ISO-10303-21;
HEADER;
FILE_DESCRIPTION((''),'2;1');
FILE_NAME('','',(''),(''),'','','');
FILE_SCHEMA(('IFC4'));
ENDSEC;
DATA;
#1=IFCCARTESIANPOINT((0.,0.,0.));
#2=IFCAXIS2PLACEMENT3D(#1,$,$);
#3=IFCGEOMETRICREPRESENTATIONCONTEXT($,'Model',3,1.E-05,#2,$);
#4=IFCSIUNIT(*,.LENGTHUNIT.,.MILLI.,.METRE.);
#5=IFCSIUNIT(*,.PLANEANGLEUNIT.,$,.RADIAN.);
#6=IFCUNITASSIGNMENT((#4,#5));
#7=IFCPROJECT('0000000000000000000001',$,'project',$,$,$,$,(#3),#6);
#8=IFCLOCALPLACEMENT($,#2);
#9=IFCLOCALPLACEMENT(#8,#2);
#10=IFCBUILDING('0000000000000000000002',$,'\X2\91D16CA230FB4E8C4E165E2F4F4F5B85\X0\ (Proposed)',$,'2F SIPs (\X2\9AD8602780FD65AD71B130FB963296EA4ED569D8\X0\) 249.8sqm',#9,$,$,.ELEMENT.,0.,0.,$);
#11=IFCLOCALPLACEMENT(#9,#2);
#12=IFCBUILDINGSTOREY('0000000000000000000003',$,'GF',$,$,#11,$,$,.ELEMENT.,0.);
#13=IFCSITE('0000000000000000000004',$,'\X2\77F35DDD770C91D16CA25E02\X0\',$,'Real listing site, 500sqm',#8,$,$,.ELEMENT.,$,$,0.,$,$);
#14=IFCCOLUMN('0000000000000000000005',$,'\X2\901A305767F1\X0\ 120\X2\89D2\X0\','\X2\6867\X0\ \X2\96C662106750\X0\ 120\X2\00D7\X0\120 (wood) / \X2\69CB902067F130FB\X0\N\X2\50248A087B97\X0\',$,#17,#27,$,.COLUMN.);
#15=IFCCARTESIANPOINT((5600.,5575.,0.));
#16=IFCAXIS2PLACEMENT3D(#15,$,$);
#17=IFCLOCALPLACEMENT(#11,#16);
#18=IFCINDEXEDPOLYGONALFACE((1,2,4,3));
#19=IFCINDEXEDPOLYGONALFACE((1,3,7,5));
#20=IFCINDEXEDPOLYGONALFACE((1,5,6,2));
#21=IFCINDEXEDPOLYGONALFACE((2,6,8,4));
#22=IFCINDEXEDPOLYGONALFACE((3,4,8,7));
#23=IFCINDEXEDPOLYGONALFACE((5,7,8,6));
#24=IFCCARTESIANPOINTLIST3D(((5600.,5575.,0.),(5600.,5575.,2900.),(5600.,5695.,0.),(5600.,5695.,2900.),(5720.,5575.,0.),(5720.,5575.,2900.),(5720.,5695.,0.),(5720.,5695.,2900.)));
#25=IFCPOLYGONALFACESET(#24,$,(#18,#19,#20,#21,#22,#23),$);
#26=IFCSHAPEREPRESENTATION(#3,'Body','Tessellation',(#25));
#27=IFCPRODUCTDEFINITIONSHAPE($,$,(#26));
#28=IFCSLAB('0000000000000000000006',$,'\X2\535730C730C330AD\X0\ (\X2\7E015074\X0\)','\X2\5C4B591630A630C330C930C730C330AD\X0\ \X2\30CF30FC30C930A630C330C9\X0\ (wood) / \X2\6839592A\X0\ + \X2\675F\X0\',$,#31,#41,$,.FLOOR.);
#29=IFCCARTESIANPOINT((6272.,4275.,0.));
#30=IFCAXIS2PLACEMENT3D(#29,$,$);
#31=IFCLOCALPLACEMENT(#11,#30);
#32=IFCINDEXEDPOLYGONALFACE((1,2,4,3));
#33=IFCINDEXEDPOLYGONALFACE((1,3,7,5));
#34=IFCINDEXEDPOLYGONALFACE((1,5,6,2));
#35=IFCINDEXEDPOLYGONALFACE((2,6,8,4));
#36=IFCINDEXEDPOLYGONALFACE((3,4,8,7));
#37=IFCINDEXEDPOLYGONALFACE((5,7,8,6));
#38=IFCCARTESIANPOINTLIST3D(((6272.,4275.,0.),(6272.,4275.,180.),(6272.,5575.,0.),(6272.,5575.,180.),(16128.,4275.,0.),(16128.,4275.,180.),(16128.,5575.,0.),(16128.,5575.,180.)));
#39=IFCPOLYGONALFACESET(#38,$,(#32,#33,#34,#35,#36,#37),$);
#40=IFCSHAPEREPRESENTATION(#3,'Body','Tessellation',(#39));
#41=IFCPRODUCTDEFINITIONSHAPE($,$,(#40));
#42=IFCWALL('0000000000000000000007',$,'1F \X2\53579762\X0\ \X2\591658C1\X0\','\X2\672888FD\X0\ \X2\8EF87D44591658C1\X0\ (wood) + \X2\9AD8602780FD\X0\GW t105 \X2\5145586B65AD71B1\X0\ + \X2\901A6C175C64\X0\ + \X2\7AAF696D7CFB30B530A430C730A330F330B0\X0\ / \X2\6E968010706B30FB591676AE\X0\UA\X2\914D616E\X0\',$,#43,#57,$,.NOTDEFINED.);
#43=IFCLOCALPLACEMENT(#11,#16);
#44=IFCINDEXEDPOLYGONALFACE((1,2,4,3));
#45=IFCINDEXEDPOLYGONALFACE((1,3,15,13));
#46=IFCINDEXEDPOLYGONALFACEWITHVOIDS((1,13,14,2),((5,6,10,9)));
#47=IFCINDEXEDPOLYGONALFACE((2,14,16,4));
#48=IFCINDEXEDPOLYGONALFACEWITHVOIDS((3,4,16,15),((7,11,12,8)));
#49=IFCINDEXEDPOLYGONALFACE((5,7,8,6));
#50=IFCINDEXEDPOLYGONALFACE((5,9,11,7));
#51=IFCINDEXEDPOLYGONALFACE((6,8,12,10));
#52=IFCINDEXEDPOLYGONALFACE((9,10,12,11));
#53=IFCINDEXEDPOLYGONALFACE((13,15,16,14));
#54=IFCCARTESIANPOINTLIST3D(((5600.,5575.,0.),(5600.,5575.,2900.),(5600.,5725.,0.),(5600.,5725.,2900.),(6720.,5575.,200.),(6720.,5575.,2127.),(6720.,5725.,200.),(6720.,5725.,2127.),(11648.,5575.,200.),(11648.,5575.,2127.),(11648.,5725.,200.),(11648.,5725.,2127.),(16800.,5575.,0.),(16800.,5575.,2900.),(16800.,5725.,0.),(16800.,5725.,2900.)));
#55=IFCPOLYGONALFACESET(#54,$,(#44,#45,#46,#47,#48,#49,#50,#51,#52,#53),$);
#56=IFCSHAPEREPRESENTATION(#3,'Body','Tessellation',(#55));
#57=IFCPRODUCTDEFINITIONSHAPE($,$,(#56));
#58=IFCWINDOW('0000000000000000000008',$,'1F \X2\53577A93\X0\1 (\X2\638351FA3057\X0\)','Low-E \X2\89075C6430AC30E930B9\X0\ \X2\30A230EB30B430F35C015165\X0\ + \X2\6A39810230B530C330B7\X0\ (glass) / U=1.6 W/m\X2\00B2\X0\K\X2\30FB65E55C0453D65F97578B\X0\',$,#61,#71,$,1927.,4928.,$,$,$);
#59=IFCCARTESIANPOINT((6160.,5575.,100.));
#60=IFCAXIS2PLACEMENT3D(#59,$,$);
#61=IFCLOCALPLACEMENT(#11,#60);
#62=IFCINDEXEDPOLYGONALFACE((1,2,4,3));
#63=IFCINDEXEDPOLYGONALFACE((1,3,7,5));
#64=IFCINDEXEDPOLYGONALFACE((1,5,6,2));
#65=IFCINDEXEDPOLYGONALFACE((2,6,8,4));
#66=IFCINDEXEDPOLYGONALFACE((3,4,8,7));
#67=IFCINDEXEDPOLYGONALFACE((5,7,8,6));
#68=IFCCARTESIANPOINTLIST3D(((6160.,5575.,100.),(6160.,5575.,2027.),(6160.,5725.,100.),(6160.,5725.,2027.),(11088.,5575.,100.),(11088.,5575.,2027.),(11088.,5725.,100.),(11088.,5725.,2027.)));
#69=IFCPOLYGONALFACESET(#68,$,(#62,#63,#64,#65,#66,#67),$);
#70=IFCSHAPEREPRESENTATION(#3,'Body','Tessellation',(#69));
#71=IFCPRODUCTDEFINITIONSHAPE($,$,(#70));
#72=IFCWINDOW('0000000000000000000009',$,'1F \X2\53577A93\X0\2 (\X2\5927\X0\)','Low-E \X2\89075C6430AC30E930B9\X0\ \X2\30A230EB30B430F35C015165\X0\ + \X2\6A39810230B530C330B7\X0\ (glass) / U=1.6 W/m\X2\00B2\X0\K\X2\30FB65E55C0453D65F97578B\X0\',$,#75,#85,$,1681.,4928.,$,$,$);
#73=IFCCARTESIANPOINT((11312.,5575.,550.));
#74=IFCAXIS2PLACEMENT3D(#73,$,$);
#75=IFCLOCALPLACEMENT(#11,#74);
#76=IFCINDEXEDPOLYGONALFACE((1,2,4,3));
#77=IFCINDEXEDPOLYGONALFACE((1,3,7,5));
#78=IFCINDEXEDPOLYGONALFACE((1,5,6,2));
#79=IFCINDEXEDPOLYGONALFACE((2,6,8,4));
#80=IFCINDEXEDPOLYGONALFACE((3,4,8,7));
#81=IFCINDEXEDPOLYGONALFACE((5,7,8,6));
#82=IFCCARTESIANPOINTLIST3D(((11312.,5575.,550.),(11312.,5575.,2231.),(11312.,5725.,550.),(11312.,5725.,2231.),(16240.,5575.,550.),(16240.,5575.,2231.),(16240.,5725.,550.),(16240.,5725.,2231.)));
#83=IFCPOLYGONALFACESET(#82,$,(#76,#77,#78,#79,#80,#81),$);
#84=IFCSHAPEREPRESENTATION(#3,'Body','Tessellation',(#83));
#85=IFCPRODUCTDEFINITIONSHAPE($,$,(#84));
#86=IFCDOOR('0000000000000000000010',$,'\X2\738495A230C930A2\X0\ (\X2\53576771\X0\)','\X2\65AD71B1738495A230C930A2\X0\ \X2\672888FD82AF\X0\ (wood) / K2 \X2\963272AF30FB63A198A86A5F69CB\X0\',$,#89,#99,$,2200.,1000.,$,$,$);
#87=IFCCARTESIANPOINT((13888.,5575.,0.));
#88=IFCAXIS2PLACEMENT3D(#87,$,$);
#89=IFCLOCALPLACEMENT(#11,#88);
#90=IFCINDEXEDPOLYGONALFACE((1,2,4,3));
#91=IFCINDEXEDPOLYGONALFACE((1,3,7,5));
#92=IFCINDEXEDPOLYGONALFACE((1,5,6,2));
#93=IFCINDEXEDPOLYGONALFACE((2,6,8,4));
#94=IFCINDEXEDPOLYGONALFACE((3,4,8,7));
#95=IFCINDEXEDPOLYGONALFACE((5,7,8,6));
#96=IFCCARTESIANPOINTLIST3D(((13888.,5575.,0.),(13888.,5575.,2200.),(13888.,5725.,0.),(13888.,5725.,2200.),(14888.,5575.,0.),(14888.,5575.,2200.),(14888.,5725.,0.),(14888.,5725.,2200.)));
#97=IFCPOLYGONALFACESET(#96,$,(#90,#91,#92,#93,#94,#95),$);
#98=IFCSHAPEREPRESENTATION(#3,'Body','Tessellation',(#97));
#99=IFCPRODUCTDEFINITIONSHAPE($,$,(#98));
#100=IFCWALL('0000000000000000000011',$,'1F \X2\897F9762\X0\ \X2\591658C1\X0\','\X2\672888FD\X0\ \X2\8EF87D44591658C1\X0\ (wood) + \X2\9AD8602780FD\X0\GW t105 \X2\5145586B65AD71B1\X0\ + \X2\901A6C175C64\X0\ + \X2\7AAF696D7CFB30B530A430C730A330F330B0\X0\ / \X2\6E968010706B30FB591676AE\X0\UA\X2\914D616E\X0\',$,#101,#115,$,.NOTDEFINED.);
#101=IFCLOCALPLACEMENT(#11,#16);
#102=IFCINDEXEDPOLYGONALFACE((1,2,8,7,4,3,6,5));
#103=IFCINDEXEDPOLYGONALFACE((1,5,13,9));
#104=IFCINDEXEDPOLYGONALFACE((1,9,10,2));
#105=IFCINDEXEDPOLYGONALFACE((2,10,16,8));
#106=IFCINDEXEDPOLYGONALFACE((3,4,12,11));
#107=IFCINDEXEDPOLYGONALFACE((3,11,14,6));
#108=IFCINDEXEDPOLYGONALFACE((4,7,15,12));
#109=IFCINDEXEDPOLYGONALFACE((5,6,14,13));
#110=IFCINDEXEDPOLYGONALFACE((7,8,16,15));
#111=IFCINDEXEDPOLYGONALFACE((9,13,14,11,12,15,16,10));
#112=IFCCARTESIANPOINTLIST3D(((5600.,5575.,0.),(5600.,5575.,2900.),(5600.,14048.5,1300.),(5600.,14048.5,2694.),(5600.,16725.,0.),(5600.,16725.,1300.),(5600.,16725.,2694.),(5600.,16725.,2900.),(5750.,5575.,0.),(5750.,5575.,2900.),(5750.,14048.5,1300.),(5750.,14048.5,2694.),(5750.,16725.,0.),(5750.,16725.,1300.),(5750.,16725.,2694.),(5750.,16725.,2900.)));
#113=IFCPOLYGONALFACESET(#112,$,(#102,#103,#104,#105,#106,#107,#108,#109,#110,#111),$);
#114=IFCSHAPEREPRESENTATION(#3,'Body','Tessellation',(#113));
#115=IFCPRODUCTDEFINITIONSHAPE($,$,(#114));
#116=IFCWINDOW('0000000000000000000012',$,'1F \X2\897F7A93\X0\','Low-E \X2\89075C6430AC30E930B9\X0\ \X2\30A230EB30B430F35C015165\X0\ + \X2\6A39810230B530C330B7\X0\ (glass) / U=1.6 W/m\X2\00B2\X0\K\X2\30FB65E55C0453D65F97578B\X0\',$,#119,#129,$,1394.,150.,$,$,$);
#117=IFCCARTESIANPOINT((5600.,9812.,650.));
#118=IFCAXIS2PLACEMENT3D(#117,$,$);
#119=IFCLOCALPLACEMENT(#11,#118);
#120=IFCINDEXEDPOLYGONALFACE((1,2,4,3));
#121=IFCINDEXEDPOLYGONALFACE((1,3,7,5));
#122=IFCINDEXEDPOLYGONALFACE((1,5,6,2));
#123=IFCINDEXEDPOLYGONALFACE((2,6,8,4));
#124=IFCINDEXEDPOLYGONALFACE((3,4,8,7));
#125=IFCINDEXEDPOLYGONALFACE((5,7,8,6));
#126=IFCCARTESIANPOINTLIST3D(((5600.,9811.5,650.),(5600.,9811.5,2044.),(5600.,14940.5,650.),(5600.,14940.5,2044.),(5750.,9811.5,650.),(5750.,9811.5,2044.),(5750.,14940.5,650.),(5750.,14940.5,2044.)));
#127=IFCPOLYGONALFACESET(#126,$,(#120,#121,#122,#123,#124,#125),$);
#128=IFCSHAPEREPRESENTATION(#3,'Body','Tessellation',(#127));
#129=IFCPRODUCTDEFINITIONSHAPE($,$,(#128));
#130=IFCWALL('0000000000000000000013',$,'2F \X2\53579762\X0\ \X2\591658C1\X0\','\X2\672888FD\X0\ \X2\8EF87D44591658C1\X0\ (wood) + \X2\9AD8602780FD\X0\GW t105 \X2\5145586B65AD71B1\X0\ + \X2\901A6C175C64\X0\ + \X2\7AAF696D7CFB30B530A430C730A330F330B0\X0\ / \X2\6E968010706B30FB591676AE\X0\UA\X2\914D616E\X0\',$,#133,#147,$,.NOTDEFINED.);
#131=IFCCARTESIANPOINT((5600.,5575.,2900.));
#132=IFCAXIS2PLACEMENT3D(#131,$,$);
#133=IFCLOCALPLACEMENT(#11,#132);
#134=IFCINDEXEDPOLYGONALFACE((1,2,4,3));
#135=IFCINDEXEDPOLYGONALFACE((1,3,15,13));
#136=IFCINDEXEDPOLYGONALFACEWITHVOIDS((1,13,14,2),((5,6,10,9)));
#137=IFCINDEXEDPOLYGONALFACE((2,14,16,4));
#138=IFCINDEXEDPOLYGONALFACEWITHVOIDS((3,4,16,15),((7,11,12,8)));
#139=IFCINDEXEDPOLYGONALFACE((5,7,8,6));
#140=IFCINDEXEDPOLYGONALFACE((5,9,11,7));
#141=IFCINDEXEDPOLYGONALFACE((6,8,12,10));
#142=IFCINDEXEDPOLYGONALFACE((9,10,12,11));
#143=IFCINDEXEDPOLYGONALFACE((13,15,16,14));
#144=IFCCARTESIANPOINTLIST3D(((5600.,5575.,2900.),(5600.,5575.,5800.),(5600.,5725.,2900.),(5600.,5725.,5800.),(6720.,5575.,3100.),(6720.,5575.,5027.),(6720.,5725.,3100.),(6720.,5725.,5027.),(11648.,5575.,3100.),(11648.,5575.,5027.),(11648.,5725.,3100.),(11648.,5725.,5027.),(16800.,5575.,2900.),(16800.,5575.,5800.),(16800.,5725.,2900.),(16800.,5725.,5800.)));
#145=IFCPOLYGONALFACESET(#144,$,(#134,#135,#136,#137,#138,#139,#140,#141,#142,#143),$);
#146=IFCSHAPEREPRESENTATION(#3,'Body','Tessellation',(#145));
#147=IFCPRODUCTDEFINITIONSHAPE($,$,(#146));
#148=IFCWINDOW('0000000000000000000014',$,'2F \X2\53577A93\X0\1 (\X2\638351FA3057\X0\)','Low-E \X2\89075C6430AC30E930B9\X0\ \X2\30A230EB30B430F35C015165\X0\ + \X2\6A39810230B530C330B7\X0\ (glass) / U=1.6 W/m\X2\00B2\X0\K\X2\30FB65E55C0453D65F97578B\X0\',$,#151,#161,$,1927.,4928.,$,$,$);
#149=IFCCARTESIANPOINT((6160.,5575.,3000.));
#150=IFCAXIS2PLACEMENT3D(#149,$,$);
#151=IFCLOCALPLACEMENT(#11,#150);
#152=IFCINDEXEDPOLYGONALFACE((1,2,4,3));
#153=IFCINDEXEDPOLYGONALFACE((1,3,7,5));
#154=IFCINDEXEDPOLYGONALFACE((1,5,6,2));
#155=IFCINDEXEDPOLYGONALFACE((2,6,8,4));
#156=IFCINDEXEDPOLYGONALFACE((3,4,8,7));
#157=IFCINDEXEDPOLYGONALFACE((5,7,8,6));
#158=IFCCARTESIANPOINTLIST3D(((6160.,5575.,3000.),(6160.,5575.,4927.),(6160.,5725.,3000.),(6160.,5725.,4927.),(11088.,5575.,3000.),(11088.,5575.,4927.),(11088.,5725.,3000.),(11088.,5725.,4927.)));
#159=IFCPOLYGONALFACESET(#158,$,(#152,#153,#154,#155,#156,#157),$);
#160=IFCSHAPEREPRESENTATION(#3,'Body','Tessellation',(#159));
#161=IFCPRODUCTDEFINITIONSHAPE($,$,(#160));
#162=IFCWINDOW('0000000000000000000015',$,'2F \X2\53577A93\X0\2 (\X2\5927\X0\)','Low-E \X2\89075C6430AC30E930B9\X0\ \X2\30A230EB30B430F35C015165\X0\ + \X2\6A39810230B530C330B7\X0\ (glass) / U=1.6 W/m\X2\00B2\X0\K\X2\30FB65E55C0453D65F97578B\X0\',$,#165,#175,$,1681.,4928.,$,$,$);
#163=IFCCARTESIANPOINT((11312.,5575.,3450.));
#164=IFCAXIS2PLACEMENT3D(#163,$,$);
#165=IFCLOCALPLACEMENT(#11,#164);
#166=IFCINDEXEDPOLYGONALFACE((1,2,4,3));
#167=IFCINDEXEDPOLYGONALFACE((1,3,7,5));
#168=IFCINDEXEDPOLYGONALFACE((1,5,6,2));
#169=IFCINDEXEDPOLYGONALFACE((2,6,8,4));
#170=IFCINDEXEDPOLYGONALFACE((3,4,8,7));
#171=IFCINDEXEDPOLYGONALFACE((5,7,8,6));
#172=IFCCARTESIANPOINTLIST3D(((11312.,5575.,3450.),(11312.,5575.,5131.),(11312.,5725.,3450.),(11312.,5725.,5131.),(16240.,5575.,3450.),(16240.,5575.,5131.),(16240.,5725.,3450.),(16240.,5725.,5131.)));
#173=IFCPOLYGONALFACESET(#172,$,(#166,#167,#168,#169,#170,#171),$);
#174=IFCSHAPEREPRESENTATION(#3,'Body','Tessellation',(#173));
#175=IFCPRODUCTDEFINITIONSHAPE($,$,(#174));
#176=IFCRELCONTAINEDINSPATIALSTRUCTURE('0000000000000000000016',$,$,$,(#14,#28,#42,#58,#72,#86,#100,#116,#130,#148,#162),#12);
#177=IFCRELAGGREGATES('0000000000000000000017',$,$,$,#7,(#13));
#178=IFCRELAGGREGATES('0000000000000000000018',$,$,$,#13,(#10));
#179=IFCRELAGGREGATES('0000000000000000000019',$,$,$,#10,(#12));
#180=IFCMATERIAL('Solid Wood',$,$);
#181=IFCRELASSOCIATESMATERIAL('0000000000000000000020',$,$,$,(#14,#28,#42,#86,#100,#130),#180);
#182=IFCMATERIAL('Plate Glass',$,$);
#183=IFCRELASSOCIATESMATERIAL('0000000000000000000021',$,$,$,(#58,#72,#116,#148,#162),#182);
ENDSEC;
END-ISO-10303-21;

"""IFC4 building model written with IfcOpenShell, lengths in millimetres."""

from ifc_helpers import new_model, si_unit, frame, frame_2d, origin, place, context, project, spatial, rectangle, extrude, material, element, fill, save


model = new_model("IFC4")

# Units and contexts
model_context = context("Model", 3, precision=1e-05, world=origin())
ifc_project = project(units=[si_unit("LENGTHUNIT", "METRE", prefix="MILLI"), si_unit("PLANEANGLEUNIT", "RADIAN")], contexts=[model_context])

# Site, building, storey
site_placement = place(None, origin())
site = spatial("IfcSite", under=ifc_project, at=site_placement, Name="石川県金沢市", ObjectType="Real listing site, 500sqm", CompositionType="ELEMENT", RefElevation=0.0)
building_placement = place(site_placement, origin())
building = spatial("IfcBuilding", under=site, at=building_placement, Name="金沢・二世帯住宅 (Proposed)", ObjectType="2F SIPs (高性能断熱・防雪仕様) 249.8sqm", CompositionType="ELEMENT", ElevationOfRefHeight=0.0, ElevationOfTerrain=0.0)
storey_placement = place(building_placement, origin())
storey = spatial("IfcBuildingStorey", under=building, at=storey_placement, Name="GF", CompositionType="ELEMENT", Elevation=0.0)

# Column
ifc_material_1 = material(Name="Solid Wood")
column_placement = place(storey_placement, frame((5600.0, 5575.0, 0.0)))
element("IfcColumn", 1, at=column_placement, inside=storey, material=ifc_material_1, Name="通し柱 120角", Description="桧 集成材 120×120 (wood) / 構造柱・N値計算", PredefinedType="COLUMN", context=model_context, shape_type="SweptSolid", body=[
    extrude(rectangle(XDim=120.0, YDim=120.0, at=frame_2d((60.0, 60.0))), frame((5600.0, 5575.0, 0.0)), (0.0, 0.0, 1.0), 2900.0),
])

# Slab
slab_1_placement = place(storey_placement, frame((6272.0, 4275.0, 0.0)))
element("IfcSlab", 2, at=slab_1_placement, inside=storey, material=ifc_material_1, Name="南デッキ (縁側)", Description="屋外ウッドデッキ ハードウッド (wood) / 根太 + 束", PredefinedType="FLOOR", context=model_context, shape_type="SweptSolid", body=[
    extrude(rectangle(XDim=9856.0, YDim=1300.0, at=frame_2d((4928.0, 650.0))), frame((6272.0, 4275.0, 0.0)), (0.0, 0.0, 1.0), 180.0),
])

# Wall, openings, windows, door
wall_1_placement = place(storey_placement, frame((5600.0, 5575.0, 0.0)))
wall_1 = element("IfcWall", 3, at=wall_1_placement, inside=storey, material=ifc_material_1, Name="1F 南面 外壁", Description="木製 軸組外壁 (wood) + 高性能GW t105 充填断熱 + 通気層 + 窯業系サイディング / 準耐火・外皮UA配慮", PredefinedType="NOTDEFINED", context=model_context, shape_type="SweptSolid", body=[
    extrude(rectangle(XDim=11200.0, YDim=150.0, at=frame_2d((5600.0, 75.0))), frame((5600.0, 5575.0, 0.0)), (0.0, 0.0, 1.0), 2900.0),
])
opening_1_placement = place(storey_placement, frame((6160.0, 5575.0, 100.0)))
opening_1 = element("IfcOpeningElement", 4, at=opening_1_placement, cuts=wall_1, PredefinedType="NOTDEFINED", context=model_context, shape_type="SweptSolid", body=[
    extrude(rectangle(XDim=4928.0, YDim=150.0, at=frame_2d((2464.0, 75.0))), frame((6160.0, 5575.0, 100.0)), (0.0, 0.0, 1.0), 1927.0),
])
opening_2_placement = place(storey_placement, frame((11312.0, 5575.0, 550.0)))
opening_2 = element("IfcOpeningElement", 5, at=opening_2_placement, cuts=wall_1, PredefinedType="NOTDEFINED", context=model_context, shape_type="SweptSolid", body=[
    extrude(rectangle(XDim=4928.0, YDim=150.0, at=frame_2d((2464.0, 75.0))), frame((11312.0, 5575.0, 550.0)), (0.0, 0.0, 1.0), 1681.0),
])
opening_3_placement = place(storey_placement, frame((13888.0, 5575.0, 0.0)))
opening_3 = element("IfcOpeningElement", 6, at=opening_3_placement, cuts=wall_1, PredefinedType="NOTDEFINED", context=model_context, shape_type="SweptSolid", body=[
    extrude(rectangle(XDim=1000.0, YDim=150.0, at=frame_2d((500.0, 75.0))), frame((13888.0, 5575.0, 0.0)), (0.0, 0.0, 1.0), 2200.0),
])
ifc_material_2 = material(Name="Plate Glass")
window_1_placement = place(storey_placement, frame((6160.0, 5575.0, 100.0)))
window_1 = element("IfcWindow", 7, at=window_1_placement, inside=storey, material=ifc_material_2, Name="1F 南窓1 (掃出し)", Description="Low-E 複層ガラス アルゴン封入 + 樹脂サッシ (glass) / U=1.6 W/m²K・日射取得型", OverallHeight=1927.0, OverallWidth=4928.0, context=model_context, shape_type="SweptSolid", body=[
    extrude(rectangle(XDim=4928.0, YDim=150.0, at=frame_2d((2464.0, 75.0))), frame((6160.0, 5575.0, 100.0)), (0.0, 0.0, 1.0), 1927.0),
])
fill(opening_1, window_1)
window_2_placement = place(storey_placement, frame((11312.0, 5575.0, 550.0)))
window_2 = element("IfcWindow", 8, at=window_2_placement, inside=storey, material=ifc_material_2, Name="1F 南窓2 (大)", Description="Low-E 複層ガラス アルゴン封入 + 樹脂サッシ (glass) / U=1.6 W/m²K・日射取得型", OverallHeight=1681.0, OverallWidth=4928.0, context=model_context, shape_type="SweptSolid", body=[
    extrude(rectangle(XDim=4928.0, YDim=150.0, at=frame_2d((2464.0, 75.0))), frame((11312.0, 5575.0, 550.0)), (0.0, 0.0, 1.0), 1681.0),
])
fill(opening_2, window_2)
door_placement = place(storey_placement, frame((13888.0, 5575.0, 0.0)))
door = element("IfcDoor", 9, at=door_placement, inside=storey, material=ifc_material_1, Name="玄関ドア (南東)", Description="断熱玄関ドア 木製芯 (wood) / K2 防犯・採風機構", OverallHeight=2200.0, OverallWidth=1000.0, context=model_context, shape_type="SweptSolid", body=[
    extrude(rectangle(XDim=1000.0, YDim=150.0, at=frame_2d((500.0, 75.0))), frame((13888.0, 5575.0, 0.0)), (0.0, 0.0, 1.0), 2200.0),
])
fill(opening_3, door)

# Wall, opening, window
wall_2_placement = place(storey_placement, frame((5600.0, 5575.0, 0.0)))
wall_2 = element("IfcWall", 10, at=wall_2_placement, inside=storey, material=ifc_material_1, Name="1F 西面 外壁", Description="木製 軸組外壁 (wood) + 高性能GW t105 充填断熱 + 通気層 + 窯業系サイディング / 準耐火・外皮UA配慮", PredefinedType="NOTDEFINED", context=model_context, shape_type="SweptSolid", body=[
    extrude(rectangle(XDim=150.0, YDim=11150.0, at=frame_2d((75.0, 5575.0))), frame((5600.0, 5575.0, 0.0)), (0.0, 0.0, 1.0), 2900.0),
])
opening_4_placement = place(storey_placement, frame((5600.0, 9812.0, 650.0)))
opening_4 = element("IfcOpeningElement", 11, at=opening_4_placement, cuts=wall_2, PredefinedType="NOTDEFINED", context=model_context, shape_type="SweptSolid", body=[
    extrude(rectangle(XDim=150.0, YDim=5129.0, at=frame_2d((75.0, 2564.0))), frame((5600.0, 9812.0, 650.0)), (0.0, 0.0, 1.0), 1394.0),
])
window_3_placement = place(storey_placement, frame((5600.0, 9812.0, 650.0)))
window_3 = element("IfcWindow", 12, at=window_3_placement, inside=storey, material=ifc_material_2, Name="1F 西窓", Description="Low-E 複層ガラス アルゴン封入 + 樹脂サッシ (glass) / U=1.6 W/m²K・日射取得型", OverallHeight=1394.0, OverallWidth=150.0, context=model_context, shape_type="SweptSolid", body=[
    extrude(rectangle(XDim=150.0, YDim=5129.0, at=frame_2d((75.0, 2564.0))), frame((5600.0, 9812.0, 650.0)), (0.0, 0.0, 1.0), 1394.0),
])
fill(opening_4, window_3)

# Wall, openings, windows
wall_3_placement = place(storey_placement, frame((5600.0, 5575.0, 2900.0)))
wall_3 = element("IfcWall", 13, at=wall_3_placement, inside=storey, material=ifc_material_1, Name="2F 南面 外壁", Description="木製 軸組外壁 (wood) + 高性能GW t105 充填断熱 + 通気層 + 窯業系サイディング / 準耐火・外皮UA配慮", PredefinedType="NOTDEFINED", context=model_context, shape_type="SweptSolid", body=[
    extrude(rectangle(XDim=11200.0, YDim=150.0, at=frame_2d((5600.0, 75.0))), frame((5600.0, 5575.0, 2900.0)), (0.0, 0.0, 1.0), 2900.0),
])
opening_5_placement = place(storey_placement, frame((6160.0, 5575.0, 3000.0)))
opening_5 = element("IfcOpeningElement", 14, at=opening_5_placement, cuts=wall_3, PredefinedType="NOTDEFINED", context=model_context, shape_type="SweptSolid", body=[
    extrude(rectangle(XDim=4928.0, YDim=150.0, at=frame_2d((2464.0, 75.0))), frame((6160.0, 5575.0, 3000.0)), (0.0, 0.0, 1.0), 1927.0),
])
opening_6_placement = place(storey_placement, frame((11312.0, 5575.0, 3450.0)))
opening_6 = element("IfcOpeningElement", 15, at=opening_6_placement, cuts=wall_3, PredefinedType="NOTDEFINED", context=model_context, shape_type="SweptSolid", body=[
    extrude(rectangle(XDim=4928.0, YDim=150.0, at=frame_2d((2464.0, 75.0))), frame((11312.0, 5575.0, 3450.0)), (0.0, 0.0, 1.0), 1681.0),
])
window_4_placement = place(storey_placement, frame((6160.0, 5575.0, 3000.0)))
window_4 = element("IfcWindow", 16, at=window_4_placement, inside=storey, material=ifc_material_2, Name="2F 南窓1 (掃出し)", Description="Low-E 複層ガラス アルゴン封入 + 樹脂サッシ (glass) / U=1.6 W/m²K・日射取得型", OverallHeight=1927.0, OverallWidth=4928.0, context=model_context, shape_type="SweptSolid", body=[
    extrude(rectangle(XDim=4928.0, YDim=150.0, at=frame_2d((2464.0, 75.0))), frame((6160.0, 5575.0, 3000.0)), (0.0, 0.0, 1.0), 1927.0),
])
fill(opening_5, window_4)
window_5_placement = place(storey_placement, frame((11312.0, 5575.0, 3450.0)))
window_5 = element("IfcWindow", 17, at=window_5_placement, inside=storey, material=ifc_material_2, Name="2F 南窓2 (大)", Description="Low-E 複層ガラス アルゴン封入 + 樹脂サッシ (glass) / U=1.6 W/m²K・日射取得型", OverallHeight=1681.0, OverallWidth=4928.0, context=model_context, shape_type="SweptSolid", body=[
    extrude(rectangle(XDim=4928.0, YDim=150.0, at=frame_2d((2464.0, 75.0))), frame((11312.0, 5575.0, 3450.0)), (0.0, 0.0, 1.0), 1681.0),
])
fill(opening_6, window_5)

save(model, "model.ifc")
